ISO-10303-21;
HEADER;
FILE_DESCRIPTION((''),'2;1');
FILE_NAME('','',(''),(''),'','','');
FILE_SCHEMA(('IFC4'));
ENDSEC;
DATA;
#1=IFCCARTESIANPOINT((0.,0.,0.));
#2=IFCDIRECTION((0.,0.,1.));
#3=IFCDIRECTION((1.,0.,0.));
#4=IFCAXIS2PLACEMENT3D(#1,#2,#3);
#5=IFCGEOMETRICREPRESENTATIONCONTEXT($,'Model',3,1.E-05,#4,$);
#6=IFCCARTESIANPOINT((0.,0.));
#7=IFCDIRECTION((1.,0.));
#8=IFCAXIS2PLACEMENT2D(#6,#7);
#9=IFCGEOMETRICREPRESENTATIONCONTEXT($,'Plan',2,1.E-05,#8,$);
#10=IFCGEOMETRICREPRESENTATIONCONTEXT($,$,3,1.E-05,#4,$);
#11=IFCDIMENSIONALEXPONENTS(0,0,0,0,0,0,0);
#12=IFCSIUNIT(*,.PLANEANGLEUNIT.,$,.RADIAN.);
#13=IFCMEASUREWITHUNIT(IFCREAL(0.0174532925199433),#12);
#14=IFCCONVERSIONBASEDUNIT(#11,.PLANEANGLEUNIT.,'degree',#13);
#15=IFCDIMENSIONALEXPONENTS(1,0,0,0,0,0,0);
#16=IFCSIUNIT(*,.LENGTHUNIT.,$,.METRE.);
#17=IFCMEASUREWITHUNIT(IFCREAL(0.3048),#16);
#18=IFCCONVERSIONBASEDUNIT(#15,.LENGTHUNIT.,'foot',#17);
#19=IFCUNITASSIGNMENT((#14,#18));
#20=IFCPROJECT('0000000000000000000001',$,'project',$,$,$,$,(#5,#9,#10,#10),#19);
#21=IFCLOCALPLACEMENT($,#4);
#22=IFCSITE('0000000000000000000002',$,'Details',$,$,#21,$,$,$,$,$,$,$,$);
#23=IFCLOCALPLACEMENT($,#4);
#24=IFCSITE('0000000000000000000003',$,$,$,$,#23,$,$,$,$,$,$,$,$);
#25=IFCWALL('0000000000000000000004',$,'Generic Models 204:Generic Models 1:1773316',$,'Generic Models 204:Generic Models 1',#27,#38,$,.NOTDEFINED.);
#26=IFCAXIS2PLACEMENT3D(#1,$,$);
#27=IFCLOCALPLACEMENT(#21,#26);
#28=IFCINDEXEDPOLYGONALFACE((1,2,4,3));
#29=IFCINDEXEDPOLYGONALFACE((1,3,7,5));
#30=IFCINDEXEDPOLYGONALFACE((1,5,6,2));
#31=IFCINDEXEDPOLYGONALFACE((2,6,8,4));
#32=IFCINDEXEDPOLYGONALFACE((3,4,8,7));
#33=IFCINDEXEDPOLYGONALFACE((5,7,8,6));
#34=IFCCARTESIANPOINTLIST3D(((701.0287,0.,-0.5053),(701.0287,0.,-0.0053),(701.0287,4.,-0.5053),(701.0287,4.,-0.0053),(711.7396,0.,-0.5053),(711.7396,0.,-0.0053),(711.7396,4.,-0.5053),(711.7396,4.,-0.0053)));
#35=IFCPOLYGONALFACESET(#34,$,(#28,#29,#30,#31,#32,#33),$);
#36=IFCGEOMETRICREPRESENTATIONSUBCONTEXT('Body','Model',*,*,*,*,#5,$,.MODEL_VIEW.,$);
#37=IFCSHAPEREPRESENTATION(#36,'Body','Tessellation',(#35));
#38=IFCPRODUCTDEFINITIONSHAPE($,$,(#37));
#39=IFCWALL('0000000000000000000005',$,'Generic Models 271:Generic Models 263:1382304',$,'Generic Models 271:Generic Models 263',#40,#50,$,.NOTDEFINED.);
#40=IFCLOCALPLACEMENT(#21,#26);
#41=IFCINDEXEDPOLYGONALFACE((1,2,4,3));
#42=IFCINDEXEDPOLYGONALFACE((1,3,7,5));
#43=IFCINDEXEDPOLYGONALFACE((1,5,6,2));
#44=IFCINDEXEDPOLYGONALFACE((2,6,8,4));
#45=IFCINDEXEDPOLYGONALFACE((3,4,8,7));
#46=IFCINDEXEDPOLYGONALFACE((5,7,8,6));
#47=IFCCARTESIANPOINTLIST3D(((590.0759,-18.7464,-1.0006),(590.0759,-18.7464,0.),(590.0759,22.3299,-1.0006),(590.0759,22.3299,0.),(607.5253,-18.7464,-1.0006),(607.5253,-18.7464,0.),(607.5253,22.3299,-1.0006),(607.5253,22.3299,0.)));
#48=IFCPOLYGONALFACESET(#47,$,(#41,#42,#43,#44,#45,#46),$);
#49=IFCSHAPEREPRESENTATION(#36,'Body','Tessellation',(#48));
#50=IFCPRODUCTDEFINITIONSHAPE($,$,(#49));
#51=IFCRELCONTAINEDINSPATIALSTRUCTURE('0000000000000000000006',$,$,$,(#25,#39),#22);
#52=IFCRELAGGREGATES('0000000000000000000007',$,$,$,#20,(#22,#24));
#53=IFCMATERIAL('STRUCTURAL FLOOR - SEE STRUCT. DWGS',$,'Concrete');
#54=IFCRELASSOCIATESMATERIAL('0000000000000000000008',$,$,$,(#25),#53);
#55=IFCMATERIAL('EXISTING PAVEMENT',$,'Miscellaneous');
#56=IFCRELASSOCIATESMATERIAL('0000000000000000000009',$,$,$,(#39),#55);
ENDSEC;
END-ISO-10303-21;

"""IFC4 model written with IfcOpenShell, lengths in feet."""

from ifc_helpers import new_model, entity, si_unit, converted_unit, frame, frame_2d, origin_with_axes, origin_2d_with_axis, place, context, subcontext, project, spatial, rectangle, extrude, material, element, save


model = new_model("IFC4")

# Units and contexts
model_context = context("Model", 3, precision=1e-05, world=origin_with_axes())
plan_context = context("Plan", 2, precision=1e-05, world=origin_2d_with_axis())
context_of_model = context(None, 3, precision=1e-05, world=origin_with_axes())
body_context_1 = subcontext(model_context, "Body", "Model", "MODEL_VIEW")
ifc_project = project(units=[converted_unit("PLANEANGLEUNIT", "degree", entity("IfcReal", 0.0174532925199433), si_unit("PLANEANGLEUNIT", "RADIAN"), dimensions=[0, 0, 0, 0, 0, 0, 0]), converted_unit("LENGTHUNIT", "foot", entity("IfcReal", 0.3048), si_unit("LENGTHUNIT", "METRE"), dimensions=[1, 0, 0, 0, 0, 0, 0])], contexts=[model_context, plan_context, context_of_model, context_of_model])

# Site
site_1_placement = place(None, origin_with_axes())
site_1 = spatial("IfcSite", under=ifc_project, at=site_1_placement, Name="Details")

# Walls
ifc_material_1 = material(Name="STRUCTURAL FLOOR - SEE STRUCT. DWGS", Category="Concrete")
wall_1_placement = place(site_1_placement, frame((701.0287, 0.0, -0.5053), z_axis=(0.0, 0.0, 1.0), x_axis=(1.0, 0.0, 0.0)))
element("IfcWall", 1, at=wall_1_placement, inside=site_1, material=ifc_material_1, Name="Generic Models 204:Generic Models 1:1773316", ObjectType="Generic Models 204:Generic Models 1", PredefinedType="NOTDEFINED", context=body_context_1, shape_type="SweptSolid", body=[
    extrude(rectangle(XDim=4.0, YDim=10.7109, at=frame_2d((0.0, 0.0), x_axis=(1.0, 0.0))), frame((5.3554, 2.0, 0.0), z_axis=(0.0, 0.0, 1.0), x_axis=(0.0, 1.0, 0.0)), (0.0, 0.0, 1.0), 0.5),
])
ifc_material_2 = material(Name="EXISTING PAVEMENT", Category="Miscellaneous")
wall_2_placement = place(site_1_placement, frame((590.0759, -18.7464, -1.0006), z_axis=(0.0, 0.0, 1.0), x_axis=(0.0, 1.0, 0.0)))
element("IfcWall", 2, at=wall_2_placement, inside=site_1, material=ifc_material_2, Name="Generic Models 271:Generic Models 263:1382304", ObjectType="Generic Models 271:Generic Models 263", PredefinedType="NOTDEFINED", context=body_context_1, shape_type="SweptSolid", body=[
    extrude(rectangle(XDim=41.0763, YDim=17.4494, at=frame_2d((0.0, 0.0), x_axis=(1.0, 0.0))), frame((20.5382, -8.7247, 0.0)), (0.0, 0.0, 1.0), 1.0006),
])

# Site
site_2_placement = place(None, origin_with_axes())
site_2 = spatial("IfcSite", under=ifc_project, at=site_2_placement)

save(model, "model.ifc")
